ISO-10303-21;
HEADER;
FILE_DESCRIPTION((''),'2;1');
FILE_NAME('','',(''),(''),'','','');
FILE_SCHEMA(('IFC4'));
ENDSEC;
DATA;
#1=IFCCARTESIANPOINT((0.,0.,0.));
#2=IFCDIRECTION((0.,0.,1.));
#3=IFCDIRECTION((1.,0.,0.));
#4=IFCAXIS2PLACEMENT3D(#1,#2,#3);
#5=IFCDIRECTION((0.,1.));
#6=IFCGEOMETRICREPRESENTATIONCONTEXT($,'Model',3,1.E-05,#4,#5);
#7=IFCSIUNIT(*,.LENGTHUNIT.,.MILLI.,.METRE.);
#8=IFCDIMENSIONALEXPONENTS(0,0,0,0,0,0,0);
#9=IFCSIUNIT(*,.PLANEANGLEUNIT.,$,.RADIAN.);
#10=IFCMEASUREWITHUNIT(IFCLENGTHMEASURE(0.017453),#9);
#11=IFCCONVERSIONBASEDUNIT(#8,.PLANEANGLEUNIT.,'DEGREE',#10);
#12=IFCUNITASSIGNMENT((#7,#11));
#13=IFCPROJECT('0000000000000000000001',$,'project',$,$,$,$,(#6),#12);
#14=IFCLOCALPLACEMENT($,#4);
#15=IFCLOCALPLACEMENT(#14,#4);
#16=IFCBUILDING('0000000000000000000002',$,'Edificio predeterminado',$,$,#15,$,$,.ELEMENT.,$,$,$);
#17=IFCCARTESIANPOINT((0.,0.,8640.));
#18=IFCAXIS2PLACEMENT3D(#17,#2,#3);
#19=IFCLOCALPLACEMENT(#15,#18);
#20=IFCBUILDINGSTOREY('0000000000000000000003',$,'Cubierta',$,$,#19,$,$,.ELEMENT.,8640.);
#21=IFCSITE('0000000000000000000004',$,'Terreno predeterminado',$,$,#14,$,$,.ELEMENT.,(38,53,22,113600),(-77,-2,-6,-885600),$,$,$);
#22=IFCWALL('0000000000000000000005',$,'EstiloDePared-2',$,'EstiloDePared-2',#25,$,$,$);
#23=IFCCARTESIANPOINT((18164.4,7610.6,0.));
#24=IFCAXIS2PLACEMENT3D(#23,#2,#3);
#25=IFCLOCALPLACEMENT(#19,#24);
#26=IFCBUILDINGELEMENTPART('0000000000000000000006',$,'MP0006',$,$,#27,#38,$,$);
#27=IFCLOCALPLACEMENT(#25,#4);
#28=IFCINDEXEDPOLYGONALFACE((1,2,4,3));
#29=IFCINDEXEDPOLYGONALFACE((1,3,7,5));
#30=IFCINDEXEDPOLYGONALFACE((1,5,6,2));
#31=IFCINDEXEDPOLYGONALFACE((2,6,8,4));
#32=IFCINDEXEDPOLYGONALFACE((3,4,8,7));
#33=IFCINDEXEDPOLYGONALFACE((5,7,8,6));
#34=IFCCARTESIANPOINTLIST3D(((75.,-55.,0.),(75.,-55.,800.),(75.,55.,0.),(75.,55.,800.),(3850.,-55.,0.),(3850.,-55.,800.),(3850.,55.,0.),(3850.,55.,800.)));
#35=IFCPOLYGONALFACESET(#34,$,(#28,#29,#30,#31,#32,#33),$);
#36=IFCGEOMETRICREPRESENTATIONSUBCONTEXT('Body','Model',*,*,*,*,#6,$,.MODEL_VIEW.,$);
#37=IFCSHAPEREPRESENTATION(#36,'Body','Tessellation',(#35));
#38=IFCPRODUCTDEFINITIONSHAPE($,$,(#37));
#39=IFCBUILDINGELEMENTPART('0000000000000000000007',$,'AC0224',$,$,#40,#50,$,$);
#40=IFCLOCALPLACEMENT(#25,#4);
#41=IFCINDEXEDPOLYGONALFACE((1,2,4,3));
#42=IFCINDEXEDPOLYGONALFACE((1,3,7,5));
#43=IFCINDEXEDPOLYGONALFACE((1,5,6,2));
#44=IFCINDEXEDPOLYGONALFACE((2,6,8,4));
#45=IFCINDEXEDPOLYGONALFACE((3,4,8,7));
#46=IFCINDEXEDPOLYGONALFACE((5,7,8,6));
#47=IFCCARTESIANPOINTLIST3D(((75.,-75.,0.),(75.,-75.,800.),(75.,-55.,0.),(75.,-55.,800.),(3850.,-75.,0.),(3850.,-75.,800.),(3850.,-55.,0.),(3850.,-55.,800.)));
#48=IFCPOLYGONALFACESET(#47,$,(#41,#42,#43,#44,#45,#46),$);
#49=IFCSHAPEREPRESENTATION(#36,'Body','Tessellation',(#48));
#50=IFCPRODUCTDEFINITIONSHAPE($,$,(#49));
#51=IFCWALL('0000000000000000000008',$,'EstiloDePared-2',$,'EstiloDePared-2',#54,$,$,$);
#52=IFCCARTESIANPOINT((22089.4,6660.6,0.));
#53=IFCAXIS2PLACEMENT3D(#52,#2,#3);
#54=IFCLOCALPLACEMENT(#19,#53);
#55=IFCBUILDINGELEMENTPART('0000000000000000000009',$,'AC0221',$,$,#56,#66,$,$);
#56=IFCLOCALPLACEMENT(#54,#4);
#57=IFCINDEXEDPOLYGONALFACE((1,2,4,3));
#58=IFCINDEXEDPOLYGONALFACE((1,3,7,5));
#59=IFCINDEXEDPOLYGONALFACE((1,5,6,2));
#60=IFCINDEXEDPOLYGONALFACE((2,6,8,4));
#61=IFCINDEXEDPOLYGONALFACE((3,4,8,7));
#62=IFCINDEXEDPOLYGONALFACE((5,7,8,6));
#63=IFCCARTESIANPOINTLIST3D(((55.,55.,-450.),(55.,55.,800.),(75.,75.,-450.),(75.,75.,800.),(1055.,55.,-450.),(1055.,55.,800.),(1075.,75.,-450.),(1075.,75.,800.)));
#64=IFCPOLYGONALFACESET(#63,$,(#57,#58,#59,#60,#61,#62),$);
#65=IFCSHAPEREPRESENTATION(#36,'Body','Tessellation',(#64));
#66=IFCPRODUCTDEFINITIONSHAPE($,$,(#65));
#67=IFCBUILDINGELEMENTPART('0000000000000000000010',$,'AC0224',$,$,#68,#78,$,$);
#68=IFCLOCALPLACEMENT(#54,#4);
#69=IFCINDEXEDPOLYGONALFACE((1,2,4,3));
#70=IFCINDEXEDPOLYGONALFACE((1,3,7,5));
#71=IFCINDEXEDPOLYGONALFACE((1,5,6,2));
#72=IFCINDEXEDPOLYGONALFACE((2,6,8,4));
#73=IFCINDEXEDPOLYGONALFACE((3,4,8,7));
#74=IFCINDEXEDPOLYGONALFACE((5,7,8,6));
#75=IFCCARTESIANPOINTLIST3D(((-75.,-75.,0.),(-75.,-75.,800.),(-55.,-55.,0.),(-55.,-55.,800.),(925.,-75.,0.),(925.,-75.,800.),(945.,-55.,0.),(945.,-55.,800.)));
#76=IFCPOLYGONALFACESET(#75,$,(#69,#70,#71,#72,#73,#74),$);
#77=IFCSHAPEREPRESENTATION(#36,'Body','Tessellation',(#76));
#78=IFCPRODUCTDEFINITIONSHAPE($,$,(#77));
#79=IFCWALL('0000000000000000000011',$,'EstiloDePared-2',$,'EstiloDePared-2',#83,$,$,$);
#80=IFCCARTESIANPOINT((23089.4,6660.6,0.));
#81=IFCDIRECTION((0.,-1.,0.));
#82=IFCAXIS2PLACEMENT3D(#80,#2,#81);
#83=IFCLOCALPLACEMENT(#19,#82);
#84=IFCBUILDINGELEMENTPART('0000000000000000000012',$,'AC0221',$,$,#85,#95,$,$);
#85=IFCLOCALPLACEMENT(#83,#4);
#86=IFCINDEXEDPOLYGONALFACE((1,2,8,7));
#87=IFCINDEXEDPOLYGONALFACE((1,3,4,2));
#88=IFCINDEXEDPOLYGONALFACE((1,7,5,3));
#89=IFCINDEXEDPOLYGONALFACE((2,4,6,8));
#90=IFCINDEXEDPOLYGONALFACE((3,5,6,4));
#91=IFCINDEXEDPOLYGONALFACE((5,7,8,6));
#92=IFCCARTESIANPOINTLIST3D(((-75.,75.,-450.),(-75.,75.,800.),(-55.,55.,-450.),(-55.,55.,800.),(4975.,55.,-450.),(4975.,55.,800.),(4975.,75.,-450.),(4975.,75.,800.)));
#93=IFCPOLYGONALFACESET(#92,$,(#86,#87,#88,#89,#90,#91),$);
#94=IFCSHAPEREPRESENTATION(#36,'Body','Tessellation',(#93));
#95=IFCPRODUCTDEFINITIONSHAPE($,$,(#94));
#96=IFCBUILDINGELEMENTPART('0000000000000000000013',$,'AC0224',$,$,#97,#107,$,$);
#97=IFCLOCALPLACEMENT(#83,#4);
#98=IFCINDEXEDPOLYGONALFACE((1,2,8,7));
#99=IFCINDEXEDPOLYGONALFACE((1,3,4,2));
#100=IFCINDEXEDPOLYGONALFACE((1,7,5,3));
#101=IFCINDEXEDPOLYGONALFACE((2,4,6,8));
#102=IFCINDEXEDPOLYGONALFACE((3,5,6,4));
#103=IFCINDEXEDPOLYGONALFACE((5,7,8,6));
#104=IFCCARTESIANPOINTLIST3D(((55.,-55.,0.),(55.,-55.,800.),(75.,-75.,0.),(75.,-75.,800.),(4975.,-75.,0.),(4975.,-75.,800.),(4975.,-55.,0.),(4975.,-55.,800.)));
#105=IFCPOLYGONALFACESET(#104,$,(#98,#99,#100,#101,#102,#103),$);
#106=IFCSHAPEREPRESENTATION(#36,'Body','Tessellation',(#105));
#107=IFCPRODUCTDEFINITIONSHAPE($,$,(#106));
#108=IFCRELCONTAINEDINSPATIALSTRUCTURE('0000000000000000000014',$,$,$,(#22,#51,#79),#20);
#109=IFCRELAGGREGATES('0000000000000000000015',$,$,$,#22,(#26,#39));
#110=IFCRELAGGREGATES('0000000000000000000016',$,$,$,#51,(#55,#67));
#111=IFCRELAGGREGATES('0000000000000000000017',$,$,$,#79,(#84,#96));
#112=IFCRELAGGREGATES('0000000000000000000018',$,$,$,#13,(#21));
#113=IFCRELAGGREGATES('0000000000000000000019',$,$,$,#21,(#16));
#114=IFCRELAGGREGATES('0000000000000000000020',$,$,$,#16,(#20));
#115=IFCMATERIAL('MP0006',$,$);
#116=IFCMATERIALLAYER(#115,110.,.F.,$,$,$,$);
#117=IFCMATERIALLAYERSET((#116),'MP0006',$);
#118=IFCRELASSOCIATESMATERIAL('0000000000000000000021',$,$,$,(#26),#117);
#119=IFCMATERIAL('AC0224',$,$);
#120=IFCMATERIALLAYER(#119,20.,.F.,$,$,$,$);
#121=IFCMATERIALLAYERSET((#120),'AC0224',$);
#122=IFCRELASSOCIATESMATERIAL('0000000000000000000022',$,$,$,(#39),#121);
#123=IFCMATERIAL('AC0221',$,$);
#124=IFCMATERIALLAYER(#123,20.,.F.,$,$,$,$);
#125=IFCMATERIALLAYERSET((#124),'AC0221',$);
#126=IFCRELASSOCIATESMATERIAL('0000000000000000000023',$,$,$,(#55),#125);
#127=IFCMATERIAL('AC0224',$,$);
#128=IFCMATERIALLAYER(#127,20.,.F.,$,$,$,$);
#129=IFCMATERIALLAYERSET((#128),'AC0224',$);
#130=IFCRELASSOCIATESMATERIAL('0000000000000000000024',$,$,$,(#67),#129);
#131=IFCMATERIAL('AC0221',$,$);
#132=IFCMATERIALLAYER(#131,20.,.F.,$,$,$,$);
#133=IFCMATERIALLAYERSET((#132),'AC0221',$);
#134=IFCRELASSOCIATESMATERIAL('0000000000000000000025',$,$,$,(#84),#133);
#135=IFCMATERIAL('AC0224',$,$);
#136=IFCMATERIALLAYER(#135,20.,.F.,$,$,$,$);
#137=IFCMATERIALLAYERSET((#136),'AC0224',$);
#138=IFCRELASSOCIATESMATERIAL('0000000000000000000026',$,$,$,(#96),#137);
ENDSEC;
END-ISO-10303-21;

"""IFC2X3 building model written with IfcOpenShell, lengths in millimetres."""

from ifc_helpers import new_model, entity, si_unit, converted_unit, direction, frame, origin_with_axes, place, context, subcontext, project, spatial, polyline, outline, extrude, material, layer, layer_set, layer_usage, element, aggregate, save


model = new_model("IFC2X3")

# Units and contexts
model_context = context("Model", 3, precision=1e-05, world=origin_with_axes(), true_north=direction((0.0, 1.0)))
body_context = subcontext(model_context, "Body", "Model", "MODEL_VIEW")
ifc_project = project(units=[si_unit("LENGTHUNIT", "METRE", prefix="MILLI"), converted_unit("PLANEANGLEUNIT", "DEGREE", entity("IfcLengthMeasure", 0.017453), si_unit("PLANEANGLEUNIT", "RADIAN"), dimensions=[0, 0, 0, 0, 0, 0, 0])], contexts=[model_context])

# Site, building, storey
site_placement = place(None, origin_with_axes())
site = spatial("IfcSite", under=ifc_project, at=site_placement, Name="Terreno predeterminado", CompositionType="ELEMENT", RefLatitude=(38, 53, 22, 113600), RefLongitude=(-77, -2, -6, -885600))
building_placement = place(site_placement, origin_with_axes())
building = spatial("IfcBuilding", under=site, at=building_placement, Name="Edificio predeterminado", CompositionType="ELEMENT")
storey_placement = place(building_placement, frame((0.0, 0.0, 8640.0), z_axis=(0.0, 0.0, 1.0), x_axis=(1.0, 0.0, 0.0)))
storey = spatial("IfcBuildingStorey", under=building, at=storey_placement, Name="Cubierta", CompositionType="ELEMENT", Elevation=8640.0)

# Walls, building element parts
wall_1_placement = place(storey_placement, frame((18164.4, 7610.6, 0.0), z_axis=(0.0, 0.0, 1.0), x_axis=(1.0, 0.0, 0.0)))
wall_1 = element("IfcWall", 1, at=wall_1_placement, inside=storey, Name="EstiloDePared-2", ObjectType="EstiloDePared-2")
ifc_material_1 = material(Name="MP0006")
ifc_layer_1 = layer(ifc_material_1, 110.0, ventilated=False)
ifc_layer_set_1 = layer_set([ifc_layer_1], Name="MP0006")
ifc_layer_usage_1 = layer_usage(ifc_layer_set_1, "AXIS2", "NEGATIVE", -55.0)
building_element_part_1_placement = place(wall_1_placement, origin_with_axes())
building_element_part_1 = element("IfcBuildingElementPart", 2, at=building_element_part_1_placement, material=ifc_layer_usage_1, Name="MP0006", context=body_context, shape_type="SweptSolid", body=[
    extrude(outline(polyline([(3850.0, 55.0), (3850.0, -55.0), (75.0, -55.0), (75.0, 55.0), (3850.0, 55.0)])), origin_with_axes(), (0.0, 0.0, 1.0), 800.0),
])
ifc_material_2 = material(Name="AC0224")
ifc_layer_2 = layer(ifc_material_2, 20.0, ventilated=False)
ifc_layer_set_2 = layer_set([ifc_layer_2], Name="AC0224")
ifc_layer_usage_2 = layer_usage(ifc_layer_set_2, "AXIS2", "NEGATIVE", 55.0)
building_element_part_2_placement = place(wall_1_placement, origin_with_axes())
building_element_part_2 = element("IfcBuildingElementPart", 3, at=building_element_part_2_placement, material=ifc_layer_usage_2, Name="AC0224", context=body_context, shape_type="SweptSolid", body=[
    extrude(outline(polyline([(3850.0, -55.0), (3850.0, -75.0), (75.0, -75.0), (75.0, -55.0), (3850.0, -55.0)])), origin_with_axes(), (0.0, 0.0, 1.0), 800.0),
])
aggregate(wall_1, [building_element_part_1, building_element_part_2])
wall_2_placement = place(storey_placement, frame((22089.4, 6660.6, 0.0), z_axis=(0.0, 0.0, 1.0), x_axis=(1.0, 0.0, 0.0)))
wall_2 = element("IfcWall", 4, at=wall_2_placement, inside=storey, Name="EstiloDePared-2", ObjectType="EstiloDePared-2")
ifc_material_3 = material(Name="AC0221")
ifc_layer_3 = layer(ifc_material_3, 20.0, ventilated=False)
ifc_layer_set_3 = layer_set([ifc_layer_3], Name="AC0221")
ifc_layer_usage_3 = layer_usage(ifc_layer_set_3, "AXIS2", "NEGATIVE", -75.0)
building_element_part_3_placement = place(wall_2_placement, origin_with_axes())
building_element_part_3 = element("IfcBuildingElementPart", 5, at=building_element_part_3_placement, material=ifc_layer_usage_3, Name="AC0221", context=body_context, shape_type="SweptSolid", body=[
    extrude(outline(polyline([(1075.0, 75.0), (1055.0, 55.0), (55.0, 55.0), (75.0, 75.0), (1075.0, 75.0)])), frame((0.0, 0.0, -450.0), z_axis=(0.0, 0.0, 1.0), x_axis=(1.0, 0.0, 0.0)), (0.0, 0.0, 1.0), 1250.0),
])
ifc_material_4 = material(Name="AC0224")
ifc_layer_4 = layer(ifc_material_4, 20.0, ventilated=False)
ifc_layer_set_4 = layer_set([ifc_layer_4], Name="AC0224")
ifc_layer_usage_4 = layer_usage(ifc_layer_set_4, "AXIS2", "NEGATIVE", 55.0)
building_element_part_4_placement = place(wall_2_placement, origin_with_axes())
building_element_part_4 = element("IfcBuildingElementPart", 6, at=building_element_part_4_placement, material=ifc_layer_usage_4, Name="AC0224", context=body_context, shape_type="SweptSolid", body=[
    extrude(outline(polyline([(945.0, -55.0), (925.0, -75.0), (-75.0, -75.0), (-55.0, -55.0), (945.0, -55.0)])), origin_with_axes(), (0.0, 0.0, 1.0), 800.0),
])
aggregate(wall_2, [building_element_part_3, building_element_part_4])
wall_3_placement = place(storey_placement, frame((23089.4, 6660.6, 0.0), z_axis=(0.0, 0.0, 1.0), x_axis=(0.0, -1.0, 0.0)))
wall_3 = element("IfcWall", 7, at=wall_3_placement, inside=storey, Name="EstiloDePared-2", ObjectType="EstiloDePared-2")
ifc_material_5 = material(Name="AC0221")
ifc_layer_5 = layer(ifc_material_5, 20.0, ventilated=False)
ifc_layer_set_5 = layer_set([ifc_layer_5], Name="AC0221")
ifc_layer_usage_5 = layer_usage(ifc_layer_set_5, "AXIS2", "NEGATIVE", -75.0)
building_element_part_5_placement = place(wall_3_placement, origin_with_axes())
building_element_part_5 = element("IfcBuildingElementPart", 8, at=building_element_part_5_placement, material=ifc_layer_usage_5, Name="AC0221", context=body_context, shape_type="SweptSolid", body=[
    extrude(outline(polyline([(4975.0, 75.0), (4975.0, 55.0), (-55.0, 55.0), (-75.0, 75.0), (4975.0, 75.0)])), frame((0.0, 0.0, -450.0), z_axis=(0.0, 0.0, 1.0), x_axis=(1.0, 0.0, 0.0)), (0.0, 0.0, 1.0), 1250.0),
])
ifc_material_6 = material(Name="AC0224")
ifc_layer_6 = layer(ifc_material_6, 20.0, ventilated=False)
ifc_layer_set_6 = layer_set([ifc_layer_6], Name="AC0224")
ifc_layer_usage_6 = layer_usage(ifc_layer_set_6, "AXIS2", "NEGATIVE", 55.0)
building_element_part_6_placement = place(wall_3_placement, origin_with_axes())
building_element_part_6 = element("IfcBuildingElementPart", 9, at=building_element_part_6_placement, material=ifc_layer_usage_6, Name="AC0224", context=body_context, shape_type="SweptSolid", body=[
    extrude(outline(polyline([(4975.0, -55.0), (4975.0, -75.0), (75.0, -75.0), (55.0, -55.0), (4975.0, -55.0)])), origin_with_axes(), (0.0, 0.0, 1.0), 800.0),
])
aggregate(wall_3, [building_element_part_5, building_element_part_6])

save(model, "model.ifc")
